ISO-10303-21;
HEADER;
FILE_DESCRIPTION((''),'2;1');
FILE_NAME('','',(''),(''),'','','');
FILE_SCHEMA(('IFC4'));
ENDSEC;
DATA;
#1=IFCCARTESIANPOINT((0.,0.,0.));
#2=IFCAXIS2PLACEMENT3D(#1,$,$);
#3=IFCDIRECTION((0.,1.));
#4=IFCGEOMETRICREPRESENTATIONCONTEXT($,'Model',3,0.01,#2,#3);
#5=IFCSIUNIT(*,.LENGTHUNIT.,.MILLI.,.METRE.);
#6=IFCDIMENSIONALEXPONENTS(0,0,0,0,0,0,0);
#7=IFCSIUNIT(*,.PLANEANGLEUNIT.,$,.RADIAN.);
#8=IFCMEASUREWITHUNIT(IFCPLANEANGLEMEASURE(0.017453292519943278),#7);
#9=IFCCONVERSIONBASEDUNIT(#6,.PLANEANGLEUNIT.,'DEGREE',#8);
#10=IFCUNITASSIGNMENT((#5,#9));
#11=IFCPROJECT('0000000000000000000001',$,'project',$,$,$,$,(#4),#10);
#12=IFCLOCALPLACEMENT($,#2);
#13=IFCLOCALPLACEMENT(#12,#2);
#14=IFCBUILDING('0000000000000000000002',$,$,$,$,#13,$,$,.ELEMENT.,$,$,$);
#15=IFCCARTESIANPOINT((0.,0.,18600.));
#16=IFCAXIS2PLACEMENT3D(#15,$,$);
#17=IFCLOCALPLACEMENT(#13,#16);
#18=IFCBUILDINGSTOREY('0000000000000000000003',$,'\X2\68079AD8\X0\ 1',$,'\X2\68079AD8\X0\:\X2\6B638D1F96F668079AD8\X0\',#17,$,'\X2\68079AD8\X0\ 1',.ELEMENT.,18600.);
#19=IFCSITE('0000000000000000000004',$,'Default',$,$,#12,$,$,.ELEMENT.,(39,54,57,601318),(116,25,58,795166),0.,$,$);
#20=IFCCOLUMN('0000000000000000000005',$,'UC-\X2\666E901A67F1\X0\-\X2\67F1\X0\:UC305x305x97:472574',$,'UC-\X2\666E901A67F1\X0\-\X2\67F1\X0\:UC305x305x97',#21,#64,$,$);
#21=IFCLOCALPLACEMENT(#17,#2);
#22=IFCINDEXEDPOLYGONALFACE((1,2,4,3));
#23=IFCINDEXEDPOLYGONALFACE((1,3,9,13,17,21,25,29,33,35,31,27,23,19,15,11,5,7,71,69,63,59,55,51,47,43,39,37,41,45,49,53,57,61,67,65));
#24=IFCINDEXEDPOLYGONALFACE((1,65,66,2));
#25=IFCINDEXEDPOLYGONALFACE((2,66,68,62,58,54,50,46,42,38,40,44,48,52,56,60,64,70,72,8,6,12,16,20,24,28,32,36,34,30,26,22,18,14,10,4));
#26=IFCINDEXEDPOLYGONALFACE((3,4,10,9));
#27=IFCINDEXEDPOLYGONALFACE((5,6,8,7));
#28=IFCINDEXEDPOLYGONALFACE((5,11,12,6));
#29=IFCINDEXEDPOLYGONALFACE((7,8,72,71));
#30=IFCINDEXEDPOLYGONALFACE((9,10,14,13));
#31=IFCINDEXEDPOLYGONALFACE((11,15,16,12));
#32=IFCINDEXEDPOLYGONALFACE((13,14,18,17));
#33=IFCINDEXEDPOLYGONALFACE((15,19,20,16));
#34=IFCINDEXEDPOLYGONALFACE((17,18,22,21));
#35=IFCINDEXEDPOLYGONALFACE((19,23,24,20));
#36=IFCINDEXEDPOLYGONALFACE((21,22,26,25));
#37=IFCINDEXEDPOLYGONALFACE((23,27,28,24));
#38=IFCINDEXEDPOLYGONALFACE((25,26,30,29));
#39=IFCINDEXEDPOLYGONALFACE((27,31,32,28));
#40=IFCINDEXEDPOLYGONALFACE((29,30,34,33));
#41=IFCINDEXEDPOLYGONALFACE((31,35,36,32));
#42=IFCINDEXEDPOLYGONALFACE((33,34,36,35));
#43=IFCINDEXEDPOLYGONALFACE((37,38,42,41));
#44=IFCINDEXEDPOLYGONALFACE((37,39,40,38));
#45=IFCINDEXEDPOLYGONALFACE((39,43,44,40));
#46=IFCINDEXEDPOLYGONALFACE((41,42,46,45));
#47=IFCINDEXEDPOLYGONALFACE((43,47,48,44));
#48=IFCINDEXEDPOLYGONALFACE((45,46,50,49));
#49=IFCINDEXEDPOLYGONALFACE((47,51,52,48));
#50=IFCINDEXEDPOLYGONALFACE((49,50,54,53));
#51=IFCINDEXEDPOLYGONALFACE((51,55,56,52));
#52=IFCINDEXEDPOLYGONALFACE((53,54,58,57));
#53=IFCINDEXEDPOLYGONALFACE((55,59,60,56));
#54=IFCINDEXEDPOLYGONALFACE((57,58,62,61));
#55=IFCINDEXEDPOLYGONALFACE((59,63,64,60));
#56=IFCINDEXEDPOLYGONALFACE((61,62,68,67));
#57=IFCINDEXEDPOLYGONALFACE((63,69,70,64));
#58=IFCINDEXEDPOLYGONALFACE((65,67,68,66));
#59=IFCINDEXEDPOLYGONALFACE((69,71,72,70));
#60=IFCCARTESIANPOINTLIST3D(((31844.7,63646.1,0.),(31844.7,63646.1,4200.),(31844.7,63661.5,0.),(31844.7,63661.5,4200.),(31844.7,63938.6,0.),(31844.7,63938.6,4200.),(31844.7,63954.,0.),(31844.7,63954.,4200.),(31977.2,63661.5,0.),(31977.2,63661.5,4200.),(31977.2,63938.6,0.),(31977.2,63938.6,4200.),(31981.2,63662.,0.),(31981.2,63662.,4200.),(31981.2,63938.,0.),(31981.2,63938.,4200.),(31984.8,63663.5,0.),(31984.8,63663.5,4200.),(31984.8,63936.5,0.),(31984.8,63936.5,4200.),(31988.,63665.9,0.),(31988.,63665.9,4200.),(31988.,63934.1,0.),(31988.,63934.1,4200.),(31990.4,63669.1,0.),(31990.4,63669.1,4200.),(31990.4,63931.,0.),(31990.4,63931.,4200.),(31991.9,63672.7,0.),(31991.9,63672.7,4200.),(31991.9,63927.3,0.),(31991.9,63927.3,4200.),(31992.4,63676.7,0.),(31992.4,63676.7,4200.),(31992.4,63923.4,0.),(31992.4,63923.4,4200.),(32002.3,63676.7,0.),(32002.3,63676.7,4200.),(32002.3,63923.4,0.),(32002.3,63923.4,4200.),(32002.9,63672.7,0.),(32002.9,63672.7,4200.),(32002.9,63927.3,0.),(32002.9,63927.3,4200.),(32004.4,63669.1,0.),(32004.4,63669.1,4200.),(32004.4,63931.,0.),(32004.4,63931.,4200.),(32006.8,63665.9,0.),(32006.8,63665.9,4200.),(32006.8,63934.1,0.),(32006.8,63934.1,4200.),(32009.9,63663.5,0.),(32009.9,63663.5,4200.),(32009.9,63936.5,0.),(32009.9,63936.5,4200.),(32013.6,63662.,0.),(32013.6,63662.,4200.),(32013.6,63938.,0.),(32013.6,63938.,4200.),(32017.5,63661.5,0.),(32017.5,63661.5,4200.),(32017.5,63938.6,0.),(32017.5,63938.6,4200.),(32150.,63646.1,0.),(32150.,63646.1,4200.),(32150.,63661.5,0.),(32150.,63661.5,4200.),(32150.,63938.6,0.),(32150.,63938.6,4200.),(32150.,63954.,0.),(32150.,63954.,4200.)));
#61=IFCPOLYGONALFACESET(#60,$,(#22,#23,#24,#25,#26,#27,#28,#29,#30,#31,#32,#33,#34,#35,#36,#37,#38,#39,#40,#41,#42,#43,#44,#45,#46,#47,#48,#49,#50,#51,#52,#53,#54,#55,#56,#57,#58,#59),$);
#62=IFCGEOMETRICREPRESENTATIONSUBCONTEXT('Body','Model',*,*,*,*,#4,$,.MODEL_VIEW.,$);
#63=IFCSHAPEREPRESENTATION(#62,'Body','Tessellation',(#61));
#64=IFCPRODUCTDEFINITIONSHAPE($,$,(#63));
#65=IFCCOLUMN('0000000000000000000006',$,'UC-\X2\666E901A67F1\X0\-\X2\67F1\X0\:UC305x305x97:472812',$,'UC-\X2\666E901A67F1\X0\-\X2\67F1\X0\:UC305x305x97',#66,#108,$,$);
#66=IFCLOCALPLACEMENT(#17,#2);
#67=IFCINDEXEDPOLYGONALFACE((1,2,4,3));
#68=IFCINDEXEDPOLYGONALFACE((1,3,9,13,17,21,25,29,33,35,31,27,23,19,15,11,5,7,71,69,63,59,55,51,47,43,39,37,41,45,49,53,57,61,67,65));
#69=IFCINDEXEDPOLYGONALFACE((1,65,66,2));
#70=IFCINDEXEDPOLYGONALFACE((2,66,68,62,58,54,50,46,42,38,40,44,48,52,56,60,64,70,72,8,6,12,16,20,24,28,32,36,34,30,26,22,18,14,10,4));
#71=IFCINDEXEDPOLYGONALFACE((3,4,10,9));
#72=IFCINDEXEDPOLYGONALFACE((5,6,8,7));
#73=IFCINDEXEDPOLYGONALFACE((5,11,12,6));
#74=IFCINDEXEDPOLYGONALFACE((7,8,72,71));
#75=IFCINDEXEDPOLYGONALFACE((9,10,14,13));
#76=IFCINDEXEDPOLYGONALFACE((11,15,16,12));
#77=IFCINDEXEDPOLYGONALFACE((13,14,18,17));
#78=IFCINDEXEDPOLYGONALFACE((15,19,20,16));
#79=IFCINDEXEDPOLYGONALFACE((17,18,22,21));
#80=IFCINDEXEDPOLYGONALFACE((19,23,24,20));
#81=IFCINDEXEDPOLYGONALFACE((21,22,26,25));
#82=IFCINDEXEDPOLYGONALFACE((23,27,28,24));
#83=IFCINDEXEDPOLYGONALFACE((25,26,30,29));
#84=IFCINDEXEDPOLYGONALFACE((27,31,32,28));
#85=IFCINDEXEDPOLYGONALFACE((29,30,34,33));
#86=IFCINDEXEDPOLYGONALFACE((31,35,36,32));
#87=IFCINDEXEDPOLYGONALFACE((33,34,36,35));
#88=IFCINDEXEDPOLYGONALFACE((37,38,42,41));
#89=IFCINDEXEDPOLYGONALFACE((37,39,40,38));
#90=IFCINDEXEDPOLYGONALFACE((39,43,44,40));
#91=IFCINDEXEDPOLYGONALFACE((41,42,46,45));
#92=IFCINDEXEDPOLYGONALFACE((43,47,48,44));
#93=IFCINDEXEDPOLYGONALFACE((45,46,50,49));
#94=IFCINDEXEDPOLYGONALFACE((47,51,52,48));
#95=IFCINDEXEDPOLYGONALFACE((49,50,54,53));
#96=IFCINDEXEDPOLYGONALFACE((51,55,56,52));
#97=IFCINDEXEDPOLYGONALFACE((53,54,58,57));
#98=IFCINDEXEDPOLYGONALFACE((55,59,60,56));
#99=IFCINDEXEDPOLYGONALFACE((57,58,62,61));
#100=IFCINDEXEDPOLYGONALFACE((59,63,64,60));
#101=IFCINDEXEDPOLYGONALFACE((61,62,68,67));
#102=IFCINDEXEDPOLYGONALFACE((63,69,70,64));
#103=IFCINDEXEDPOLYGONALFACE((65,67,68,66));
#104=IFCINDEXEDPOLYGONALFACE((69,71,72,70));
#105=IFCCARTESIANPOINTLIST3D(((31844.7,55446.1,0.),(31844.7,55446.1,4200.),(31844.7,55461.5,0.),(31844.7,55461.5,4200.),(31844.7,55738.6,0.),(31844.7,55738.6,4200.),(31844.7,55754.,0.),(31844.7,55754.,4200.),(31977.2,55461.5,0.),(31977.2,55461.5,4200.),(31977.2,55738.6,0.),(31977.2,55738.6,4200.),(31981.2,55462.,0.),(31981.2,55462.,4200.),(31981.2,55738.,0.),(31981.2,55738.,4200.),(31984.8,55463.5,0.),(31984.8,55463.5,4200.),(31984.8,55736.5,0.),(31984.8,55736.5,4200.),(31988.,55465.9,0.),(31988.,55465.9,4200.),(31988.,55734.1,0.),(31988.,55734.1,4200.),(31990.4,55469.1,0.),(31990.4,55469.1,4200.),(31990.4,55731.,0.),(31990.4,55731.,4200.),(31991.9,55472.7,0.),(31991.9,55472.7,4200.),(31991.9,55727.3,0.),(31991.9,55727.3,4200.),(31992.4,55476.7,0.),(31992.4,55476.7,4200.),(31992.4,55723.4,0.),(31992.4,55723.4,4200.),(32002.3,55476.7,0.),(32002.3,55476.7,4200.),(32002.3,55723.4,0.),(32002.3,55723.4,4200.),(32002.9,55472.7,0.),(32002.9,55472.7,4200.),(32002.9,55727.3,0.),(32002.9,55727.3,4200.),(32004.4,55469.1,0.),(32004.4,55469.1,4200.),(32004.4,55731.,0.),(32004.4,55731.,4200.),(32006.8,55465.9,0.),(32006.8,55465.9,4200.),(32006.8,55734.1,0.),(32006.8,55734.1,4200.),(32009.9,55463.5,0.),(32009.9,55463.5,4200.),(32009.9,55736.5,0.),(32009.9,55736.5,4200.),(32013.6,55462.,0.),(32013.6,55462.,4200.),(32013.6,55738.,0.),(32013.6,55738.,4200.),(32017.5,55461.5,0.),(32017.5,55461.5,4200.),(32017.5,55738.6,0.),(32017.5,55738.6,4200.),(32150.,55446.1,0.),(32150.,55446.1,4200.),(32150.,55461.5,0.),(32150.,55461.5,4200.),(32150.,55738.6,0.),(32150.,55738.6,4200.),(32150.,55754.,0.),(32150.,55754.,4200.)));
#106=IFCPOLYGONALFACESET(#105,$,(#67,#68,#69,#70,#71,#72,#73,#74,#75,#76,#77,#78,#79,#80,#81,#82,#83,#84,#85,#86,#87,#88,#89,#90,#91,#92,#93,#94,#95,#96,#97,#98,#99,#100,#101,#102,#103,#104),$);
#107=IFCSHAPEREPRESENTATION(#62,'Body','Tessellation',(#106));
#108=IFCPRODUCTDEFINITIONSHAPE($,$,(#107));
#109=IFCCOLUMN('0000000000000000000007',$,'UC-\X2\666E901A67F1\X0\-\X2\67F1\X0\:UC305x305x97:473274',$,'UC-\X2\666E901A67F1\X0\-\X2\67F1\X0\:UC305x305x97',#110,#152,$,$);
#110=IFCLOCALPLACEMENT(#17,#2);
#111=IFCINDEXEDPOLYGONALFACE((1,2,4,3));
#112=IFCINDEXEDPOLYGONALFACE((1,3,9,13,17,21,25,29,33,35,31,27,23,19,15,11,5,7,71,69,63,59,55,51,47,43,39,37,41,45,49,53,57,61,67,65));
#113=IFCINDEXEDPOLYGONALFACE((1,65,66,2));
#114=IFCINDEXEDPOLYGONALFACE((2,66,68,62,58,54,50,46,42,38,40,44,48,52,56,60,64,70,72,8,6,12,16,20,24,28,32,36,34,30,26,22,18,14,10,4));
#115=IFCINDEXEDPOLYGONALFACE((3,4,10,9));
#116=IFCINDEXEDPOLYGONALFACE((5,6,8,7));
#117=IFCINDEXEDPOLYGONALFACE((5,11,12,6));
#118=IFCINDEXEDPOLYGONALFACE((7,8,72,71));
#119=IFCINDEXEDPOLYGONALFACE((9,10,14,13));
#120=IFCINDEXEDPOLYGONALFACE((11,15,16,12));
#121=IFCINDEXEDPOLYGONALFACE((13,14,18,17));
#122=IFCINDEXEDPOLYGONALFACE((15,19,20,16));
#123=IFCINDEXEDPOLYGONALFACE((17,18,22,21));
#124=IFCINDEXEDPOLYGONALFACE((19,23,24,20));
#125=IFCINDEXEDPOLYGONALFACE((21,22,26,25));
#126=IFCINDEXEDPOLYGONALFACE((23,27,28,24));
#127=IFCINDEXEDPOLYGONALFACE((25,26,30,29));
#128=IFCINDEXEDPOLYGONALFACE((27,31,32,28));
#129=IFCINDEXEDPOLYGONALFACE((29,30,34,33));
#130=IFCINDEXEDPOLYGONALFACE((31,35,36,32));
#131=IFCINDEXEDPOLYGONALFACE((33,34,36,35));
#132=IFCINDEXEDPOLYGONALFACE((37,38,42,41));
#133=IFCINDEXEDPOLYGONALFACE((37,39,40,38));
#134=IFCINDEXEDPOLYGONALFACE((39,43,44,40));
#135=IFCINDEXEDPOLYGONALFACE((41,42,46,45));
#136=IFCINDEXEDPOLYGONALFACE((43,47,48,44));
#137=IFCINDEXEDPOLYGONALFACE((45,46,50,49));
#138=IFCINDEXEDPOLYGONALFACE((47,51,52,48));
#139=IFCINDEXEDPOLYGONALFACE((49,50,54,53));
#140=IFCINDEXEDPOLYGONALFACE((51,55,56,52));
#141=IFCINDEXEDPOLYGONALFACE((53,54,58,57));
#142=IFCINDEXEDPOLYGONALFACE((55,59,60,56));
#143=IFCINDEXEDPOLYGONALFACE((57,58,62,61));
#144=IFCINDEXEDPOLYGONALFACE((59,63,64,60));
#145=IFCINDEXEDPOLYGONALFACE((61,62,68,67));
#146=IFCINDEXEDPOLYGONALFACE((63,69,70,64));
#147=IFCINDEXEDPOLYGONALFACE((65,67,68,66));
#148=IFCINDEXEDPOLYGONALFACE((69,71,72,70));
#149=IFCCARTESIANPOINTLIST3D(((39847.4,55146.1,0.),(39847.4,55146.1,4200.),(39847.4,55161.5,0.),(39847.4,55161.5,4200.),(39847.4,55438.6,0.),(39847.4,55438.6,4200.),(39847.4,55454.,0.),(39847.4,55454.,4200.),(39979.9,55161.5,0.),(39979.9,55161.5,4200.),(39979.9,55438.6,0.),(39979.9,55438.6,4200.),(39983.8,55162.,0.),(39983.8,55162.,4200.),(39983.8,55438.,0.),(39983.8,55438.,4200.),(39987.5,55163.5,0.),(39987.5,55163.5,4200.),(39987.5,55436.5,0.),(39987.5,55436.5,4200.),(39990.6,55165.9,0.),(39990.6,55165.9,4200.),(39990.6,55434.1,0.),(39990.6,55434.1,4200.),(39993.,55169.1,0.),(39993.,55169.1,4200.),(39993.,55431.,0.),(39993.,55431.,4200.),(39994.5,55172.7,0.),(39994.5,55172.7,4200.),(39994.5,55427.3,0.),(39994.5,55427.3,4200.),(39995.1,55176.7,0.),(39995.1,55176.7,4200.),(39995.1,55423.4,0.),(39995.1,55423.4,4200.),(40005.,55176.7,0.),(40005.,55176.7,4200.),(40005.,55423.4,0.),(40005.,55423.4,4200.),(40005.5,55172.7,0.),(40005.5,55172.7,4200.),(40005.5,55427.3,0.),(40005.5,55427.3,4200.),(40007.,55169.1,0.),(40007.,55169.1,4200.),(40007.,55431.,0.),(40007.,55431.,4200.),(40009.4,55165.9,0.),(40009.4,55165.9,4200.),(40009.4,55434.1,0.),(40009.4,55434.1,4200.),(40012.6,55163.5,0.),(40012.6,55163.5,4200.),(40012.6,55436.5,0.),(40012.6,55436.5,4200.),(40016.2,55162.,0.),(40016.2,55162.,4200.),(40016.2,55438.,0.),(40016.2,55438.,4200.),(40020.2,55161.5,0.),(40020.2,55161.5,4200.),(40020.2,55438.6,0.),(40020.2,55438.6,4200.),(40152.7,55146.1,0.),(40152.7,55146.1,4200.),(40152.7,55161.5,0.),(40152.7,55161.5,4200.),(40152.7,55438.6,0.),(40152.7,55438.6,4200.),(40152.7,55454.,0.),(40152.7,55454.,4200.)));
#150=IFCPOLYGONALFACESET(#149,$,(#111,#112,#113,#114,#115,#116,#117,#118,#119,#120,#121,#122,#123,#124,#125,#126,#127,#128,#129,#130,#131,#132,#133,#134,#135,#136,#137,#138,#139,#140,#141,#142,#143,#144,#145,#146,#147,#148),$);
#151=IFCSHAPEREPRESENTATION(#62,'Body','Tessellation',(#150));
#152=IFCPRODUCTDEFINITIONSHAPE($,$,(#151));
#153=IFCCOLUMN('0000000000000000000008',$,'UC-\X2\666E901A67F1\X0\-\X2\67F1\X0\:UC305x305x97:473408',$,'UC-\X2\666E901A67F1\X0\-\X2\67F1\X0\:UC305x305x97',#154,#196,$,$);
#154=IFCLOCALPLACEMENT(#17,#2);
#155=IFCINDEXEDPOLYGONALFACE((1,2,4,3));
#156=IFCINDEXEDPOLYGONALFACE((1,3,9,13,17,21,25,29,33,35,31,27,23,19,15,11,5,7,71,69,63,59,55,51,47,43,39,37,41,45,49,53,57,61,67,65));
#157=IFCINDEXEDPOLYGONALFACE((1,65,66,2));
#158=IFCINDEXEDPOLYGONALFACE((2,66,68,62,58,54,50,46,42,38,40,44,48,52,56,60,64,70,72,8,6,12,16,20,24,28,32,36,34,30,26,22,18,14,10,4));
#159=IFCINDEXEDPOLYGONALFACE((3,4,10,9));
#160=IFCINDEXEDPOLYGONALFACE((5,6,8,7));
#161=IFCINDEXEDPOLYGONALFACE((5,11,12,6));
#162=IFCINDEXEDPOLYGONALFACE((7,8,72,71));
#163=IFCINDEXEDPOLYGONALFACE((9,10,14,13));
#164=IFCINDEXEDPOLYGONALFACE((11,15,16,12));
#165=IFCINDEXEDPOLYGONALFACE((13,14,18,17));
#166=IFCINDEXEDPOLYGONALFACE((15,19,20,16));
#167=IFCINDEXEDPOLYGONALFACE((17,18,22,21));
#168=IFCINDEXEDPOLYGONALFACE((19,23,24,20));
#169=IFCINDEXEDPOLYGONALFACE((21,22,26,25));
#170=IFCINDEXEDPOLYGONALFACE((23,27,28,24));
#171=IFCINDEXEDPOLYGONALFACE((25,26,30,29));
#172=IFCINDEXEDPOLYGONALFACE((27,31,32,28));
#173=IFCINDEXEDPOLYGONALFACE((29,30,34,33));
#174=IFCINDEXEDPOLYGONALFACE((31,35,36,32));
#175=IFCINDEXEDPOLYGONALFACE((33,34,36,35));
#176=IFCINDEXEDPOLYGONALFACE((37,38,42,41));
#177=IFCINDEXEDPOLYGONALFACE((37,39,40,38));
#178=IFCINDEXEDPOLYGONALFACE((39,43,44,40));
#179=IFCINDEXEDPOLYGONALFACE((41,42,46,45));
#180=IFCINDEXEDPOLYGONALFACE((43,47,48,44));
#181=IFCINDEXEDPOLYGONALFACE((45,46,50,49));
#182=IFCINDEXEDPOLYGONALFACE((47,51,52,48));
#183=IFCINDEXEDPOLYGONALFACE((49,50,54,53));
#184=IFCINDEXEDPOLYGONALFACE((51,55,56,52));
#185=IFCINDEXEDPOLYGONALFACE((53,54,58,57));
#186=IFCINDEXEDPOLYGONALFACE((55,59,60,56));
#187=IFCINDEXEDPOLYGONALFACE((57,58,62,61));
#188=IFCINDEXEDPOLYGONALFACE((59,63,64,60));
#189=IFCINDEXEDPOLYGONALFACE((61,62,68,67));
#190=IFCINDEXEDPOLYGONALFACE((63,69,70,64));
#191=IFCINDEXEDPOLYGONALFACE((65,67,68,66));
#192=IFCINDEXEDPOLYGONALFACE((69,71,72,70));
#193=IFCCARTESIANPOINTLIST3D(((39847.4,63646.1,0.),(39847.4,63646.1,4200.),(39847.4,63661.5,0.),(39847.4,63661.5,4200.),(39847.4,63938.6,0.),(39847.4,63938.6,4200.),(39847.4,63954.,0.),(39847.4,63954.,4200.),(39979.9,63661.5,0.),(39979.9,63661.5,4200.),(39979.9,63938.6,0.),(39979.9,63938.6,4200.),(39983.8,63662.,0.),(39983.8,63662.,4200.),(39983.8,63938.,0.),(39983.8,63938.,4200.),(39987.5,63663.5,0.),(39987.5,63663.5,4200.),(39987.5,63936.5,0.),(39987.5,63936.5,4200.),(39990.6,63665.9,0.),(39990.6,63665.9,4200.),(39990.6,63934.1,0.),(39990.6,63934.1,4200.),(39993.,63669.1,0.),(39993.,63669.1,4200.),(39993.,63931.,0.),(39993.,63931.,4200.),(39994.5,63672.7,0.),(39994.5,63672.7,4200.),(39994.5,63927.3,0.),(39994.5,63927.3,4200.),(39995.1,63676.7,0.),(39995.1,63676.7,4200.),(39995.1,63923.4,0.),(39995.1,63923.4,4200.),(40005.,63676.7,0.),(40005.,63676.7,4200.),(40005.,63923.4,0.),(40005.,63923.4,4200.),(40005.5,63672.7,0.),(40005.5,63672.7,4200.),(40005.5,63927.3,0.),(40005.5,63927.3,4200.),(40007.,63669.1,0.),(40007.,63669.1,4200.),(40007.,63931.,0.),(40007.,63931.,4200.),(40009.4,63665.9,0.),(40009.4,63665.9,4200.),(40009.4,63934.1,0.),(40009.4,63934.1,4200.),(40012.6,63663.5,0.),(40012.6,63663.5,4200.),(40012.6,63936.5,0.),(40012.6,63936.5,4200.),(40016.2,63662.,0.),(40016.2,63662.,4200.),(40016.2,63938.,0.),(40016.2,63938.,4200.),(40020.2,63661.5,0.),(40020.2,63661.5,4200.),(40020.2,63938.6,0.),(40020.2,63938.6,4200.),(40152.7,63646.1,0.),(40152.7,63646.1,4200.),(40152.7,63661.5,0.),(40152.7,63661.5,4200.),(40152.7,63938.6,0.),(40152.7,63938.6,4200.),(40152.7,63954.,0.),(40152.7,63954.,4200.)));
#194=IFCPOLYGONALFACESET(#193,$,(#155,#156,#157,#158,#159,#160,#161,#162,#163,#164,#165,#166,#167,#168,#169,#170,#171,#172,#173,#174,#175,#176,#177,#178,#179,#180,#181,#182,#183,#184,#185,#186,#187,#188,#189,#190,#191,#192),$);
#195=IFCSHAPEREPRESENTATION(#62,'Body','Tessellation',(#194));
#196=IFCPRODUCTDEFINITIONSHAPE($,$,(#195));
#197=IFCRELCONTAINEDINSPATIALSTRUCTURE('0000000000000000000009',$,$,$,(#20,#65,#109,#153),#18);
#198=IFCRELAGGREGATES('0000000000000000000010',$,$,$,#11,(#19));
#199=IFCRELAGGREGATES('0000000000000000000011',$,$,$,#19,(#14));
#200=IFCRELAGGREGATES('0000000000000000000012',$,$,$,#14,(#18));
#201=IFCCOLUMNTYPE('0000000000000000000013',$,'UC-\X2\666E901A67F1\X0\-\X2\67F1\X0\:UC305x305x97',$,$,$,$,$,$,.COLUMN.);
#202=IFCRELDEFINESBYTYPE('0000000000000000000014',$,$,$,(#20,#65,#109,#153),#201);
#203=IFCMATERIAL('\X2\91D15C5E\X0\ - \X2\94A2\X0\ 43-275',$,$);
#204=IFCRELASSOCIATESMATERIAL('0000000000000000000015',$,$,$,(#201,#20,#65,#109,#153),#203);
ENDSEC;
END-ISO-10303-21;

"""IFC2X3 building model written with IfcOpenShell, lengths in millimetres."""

from ifc_helpers import new_model, entity, si_unit, converted_unit, direction, frame, origin, origin_2d_with_axis, place, context, subcontext, project, spatial, i_section, extrude, source, transform, mapped, material, type_object, type_shapes, element, save


model = new_model("IFC2X3")

# Units and contexts
model_context = context("Model", 3, precision=0.01, world=origin(), true_north=direction((0.0, 1.0)))
body_context = subcontext(model_context, "Body", "Model", "MODEL_VIEW")
ifc_project = project(units=[si_unit("LENGTHUNIT", "METRE", prefix="MILLI"), converted_unit("PLANEANGLEUNIT", "DEGREE", entity("IfcPlaneAngleMeasure", 0.017453292519943278), si_unit("PLANEANGLEUNIT", "RADIAN"), dimensions=[0, 0, 0, 0, 0, 0, 0])], contexts=[model_context])

# Site, building, storey
site_placement = place(None, origin())
site = spatial("IfcSite", under=ifc_project, at=site_placement, Name="Default", CompositionType="ELEMENT", RefLatitude=(39, 54, 57, 601318), RefLongitude=(116, 25, 58, 795166), RefElevation=0.0)
building_placement = place(site_placement, origin())
building = spatial("IfcBuilding", under=site, at=building_placement, CompositionType="ELEMENT")
storey_placement = place(building_placement, frame((0.0, 0.0, 18600.0)))
storey = spatial("IfcBuildingStorey", under=building, at=storey_placement, Name="标高 1", ObjectType="标高:正负零标高", LongName="标高 1", CompositionType="ELEMENT", Elevation=18600.0)

# Columns
ifc_material_1 = material(Name="金属 - 钢 43-275")
column_type = type_object("IfcColumnType", Name="UC-普通柱-柱:UC305x305x97", PredefinedType="COLUMN", material=ifc_material_1)
shared_shape_1 = source(origin(), body_context, "Body", "SweptSolid", [
    extrude(i_section(OverallWidth=305.3, OverallDepth=307.9, WebThickness=9.9, FlangeThickness=15.4, FilletRadius=15.2, at=origin_2d_with_axis()), frame((0.0, 0.0, 18600.0), z_axis=(0.0, 0.0, 1.0), x_axis=(-1.0, 0.0, 0.0)), (0.0, 0.0, 1.0), 4200.0),
])
type_shapes(column_type, [shared_shape_1])
for number, where, name in (
    (1, (31997.4, 63800.0, -18600.0), "UC-普通柱-柱:UC305x305x97:472574"),
    (2, (31997.4, 55600.0, -18600.0), "UC-普通柱-柱:UC305x305x97:472812"),
    (3, (40000.0, 55300.0, -18600.0), "UC-普通柱-柱:UC305x305x97:473274"),
    (4, (40000.0, 63800.0, -18600.0), "UC-普通柱-柱:UC305x305x97:473408"),
):
    element("IfcColumn", number, at=place(storey_placement, frame(where)), inside=storey, type_object=column_type, material=ifc_material_1, Name=name, ObjectType="UC-普通柱-柱:UC305x305x97", context=body_context, shape_type="MappedRepresentation", body=[
        mapped(shared_shape_1, transform((0.0, 0.0, 0.0), scale=1.0)),
    ])

save(model, "model.ifc")
